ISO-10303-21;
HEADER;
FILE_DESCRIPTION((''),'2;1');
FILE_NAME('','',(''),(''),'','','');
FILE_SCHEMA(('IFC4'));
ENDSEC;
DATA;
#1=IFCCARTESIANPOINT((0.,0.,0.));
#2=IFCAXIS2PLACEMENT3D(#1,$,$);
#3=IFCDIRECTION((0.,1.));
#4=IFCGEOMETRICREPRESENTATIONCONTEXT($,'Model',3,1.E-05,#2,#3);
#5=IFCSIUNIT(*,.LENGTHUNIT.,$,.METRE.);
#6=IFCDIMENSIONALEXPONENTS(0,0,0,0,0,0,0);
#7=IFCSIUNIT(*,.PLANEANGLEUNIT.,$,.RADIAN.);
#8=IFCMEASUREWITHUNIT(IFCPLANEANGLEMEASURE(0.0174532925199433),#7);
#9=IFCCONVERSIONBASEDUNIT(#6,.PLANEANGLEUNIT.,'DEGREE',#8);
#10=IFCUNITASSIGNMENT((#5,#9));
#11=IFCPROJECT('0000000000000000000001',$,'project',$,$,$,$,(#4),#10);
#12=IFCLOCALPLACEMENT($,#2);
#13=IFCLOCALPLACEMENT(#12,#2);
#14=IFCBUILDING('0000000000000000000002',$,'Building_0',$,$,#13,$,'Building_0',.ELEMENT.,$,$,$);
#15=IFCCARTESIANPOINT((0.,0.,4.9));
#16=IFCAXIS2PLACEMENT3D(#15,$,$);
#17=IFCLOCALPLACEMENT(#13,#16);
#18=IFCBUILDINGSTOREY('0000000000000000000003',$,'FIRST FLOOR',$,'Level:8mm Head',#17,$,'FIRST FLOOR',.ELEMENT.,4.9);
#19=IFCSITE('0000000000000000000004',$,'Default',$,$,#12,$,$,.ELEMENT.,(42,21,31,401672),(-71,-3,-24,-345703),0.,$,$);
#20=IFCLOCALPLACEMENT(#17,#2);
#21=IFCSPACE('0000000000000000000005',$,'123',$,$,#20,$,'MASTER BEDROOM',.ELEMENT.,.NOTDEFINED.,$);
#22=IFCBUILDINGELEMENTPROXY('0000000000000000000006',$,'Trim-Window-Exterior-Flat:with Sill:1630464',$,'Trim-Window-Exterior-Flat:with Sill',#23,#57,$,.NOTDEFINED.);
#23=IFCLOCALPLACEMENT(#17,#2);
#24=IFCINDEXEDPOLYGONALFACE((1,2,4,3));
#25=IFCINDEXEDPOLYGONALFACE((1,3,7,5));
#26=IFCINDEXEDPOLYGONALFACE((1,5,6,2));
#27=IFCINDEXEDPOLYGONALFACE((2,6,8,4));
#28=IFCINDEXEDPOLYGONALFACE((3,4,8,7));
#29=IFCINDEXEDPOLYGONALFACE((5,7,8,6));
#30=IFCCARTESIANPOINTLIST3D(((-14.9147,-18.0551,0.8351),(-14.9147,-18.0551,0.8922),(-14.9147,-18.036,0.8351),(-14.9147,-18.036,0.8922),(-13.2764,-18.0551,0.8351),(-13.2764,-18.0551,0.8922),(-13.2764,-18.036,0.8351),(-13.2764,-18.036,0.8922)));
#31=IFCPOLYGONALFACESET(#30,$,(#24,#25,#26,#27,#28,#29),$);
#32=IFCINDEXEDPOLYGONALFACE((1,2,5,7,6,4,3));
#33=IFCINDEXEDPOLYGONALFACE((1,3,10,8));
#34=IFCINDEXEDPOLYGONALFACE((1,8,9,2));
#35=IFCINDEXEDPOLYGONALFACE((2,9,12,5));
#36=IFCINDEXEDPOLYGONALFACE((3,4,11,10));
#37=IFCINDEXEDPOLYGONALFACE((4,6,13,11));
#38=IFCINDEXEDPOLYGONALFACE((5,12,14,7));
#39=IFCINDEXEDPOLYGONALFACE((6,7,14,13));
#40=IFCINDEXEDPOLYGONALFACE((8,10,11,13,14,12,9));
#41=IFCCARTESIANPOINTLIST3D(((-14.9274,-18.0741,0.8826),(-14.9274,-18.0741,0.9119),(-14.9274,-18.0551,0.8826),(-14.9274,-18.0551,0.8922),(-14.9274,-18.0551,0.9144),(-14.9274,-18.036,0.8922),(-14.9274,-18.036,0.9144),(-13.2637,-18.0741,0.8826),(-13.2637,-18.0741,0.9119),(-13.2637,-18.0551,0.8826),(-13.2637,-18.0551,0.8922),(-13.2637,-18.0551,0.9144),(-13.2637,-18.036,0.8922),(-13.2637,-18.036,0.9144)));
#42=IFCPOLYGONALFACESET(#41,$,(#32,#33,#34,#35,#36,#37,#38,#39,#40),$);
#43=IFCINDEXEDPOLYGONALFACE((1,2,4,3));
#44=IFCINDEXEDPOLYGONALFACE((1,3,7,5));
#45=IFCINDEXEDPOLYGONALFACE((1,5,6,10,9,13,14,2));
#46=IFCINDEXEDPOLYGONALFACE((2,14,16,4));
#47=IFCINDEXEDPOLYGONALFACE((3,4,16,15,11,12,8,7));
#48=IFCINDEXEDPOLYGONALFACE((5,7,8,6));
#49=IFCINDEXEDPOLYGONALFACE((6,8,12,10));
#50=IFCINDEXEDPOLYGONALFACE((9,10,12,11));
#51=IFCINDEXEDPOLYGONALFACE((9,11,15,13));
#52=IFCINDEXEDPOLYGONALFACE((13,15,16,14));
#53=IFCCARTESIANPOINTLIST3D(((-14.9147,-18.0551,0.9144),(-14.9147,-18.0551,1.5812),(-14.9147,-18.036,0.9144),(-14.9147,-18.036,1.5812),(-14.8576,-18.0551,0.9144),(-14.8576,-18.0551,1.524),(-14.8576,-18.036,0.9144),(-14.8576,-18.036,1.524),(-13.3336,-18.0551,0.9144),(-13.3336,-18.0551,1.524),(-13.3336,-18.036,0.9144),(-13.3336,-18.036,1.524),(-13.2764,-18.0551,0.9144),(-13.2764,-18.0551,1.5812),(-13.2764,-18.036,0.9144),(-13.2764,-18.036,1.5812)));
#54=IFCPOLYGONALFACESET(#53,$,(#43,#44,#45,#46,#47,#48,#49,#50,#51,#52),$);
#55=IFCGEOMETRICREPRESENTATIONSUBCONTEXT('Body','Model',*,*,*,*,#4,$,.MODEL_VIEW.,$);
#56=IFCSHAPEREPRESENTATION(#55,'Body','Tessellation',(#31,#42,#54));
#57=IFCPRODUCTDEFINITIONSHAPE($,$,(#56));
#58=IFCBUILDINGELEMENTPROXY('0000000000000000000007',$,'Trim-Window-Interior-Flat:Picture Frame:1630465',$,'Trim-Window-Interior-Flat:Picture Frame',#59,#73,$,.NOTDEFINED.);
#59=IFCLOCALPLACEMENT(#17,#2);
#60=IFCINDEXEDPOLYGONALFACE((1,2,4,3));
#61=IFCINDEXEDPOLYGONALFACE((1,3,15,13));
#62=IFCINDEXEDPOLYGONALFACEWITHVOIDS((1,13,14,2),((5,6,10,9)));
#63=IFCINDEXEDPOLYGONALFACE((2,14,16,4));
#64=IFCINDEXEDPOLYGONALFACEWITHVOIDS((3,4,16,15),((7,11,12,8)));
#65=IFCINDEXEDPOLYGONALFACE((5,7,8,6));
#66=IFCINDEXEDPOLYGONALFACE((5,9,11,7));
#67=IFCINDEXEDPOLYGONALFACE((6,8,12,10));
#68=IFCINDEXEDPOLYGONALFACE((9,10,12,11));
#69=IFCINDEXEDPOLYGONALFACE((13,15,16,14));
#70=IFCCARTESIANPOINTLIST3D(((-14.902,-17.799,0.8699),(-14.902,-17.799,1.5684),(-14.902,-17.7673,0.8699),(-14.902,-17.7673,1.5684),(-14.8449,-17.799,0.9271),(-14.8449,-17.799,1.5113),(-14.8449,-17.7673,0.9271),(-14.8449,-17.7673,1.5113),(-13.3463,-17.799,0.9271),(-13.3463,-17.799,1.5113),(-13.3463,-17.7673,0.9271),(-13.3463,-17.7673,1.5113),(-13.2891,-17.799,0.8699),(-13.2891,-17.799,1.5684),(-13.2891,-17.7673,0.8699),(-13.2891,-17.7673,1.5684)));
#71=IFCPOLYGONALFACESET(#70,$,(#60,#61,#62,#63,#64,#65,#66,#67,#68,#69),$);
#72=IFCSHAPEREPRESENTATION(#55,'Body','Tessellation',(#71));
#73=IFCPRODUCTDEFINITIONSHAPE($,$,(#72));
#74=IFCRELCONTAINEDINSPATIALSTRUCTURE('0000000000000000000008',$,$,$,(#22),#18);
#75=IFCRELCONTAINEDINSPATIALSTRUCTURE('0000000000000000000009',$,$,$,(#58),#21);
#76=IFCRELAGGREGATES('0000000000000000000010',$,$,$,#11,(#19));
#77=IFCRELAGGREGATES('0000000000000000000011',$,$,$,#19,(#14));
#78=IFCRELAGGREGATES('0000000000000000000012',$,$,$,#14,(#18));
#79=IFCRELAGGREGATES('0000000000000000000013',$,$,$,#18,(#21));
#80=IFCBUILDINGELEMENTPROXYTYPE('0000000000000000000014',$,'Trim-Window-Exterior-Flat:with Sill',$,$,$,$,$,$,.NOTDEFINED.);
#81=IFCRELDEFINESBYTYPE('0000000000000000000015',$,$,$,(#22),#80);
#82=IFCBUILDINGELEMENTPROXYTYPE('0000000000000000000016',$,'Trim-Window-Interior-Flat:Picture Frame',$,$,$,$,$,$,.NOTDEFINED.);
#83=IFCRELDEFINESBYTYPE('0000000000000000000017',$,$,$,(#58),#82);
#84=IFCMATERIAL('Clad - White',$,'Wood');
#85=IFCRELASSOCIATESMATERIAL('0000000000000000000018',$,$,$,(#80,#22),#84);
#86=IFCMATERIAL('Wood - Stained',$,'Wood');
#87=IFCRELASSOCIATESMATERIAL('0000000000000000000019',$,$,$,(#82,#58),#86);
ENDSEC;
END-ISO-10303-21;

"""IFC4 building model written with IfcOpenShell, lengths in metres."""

from ifc_helpers import new_model, entity, si_unit, converted_unit, direction, frame, origin, place, context, subcontext, project, spatial, indexed_curve, outline, extrude, source, transform, mapped, material, type_object, type_shapes, element, save


model = new_model("IFC4")

# Units and contexts
model_context = context("Model", 3, precision=1e-05, world=origin(), true_north=direction((0.0, 1.0)))
body_context = subcontext(model_context, "Body", "Model", "MODEL_VIEW")
ifc_project = project(units=[si_unit("LENGTHUNIT", "METRE"), converted_unit("PLANEANGLEUNIT", "DEGREE", entity("IfcPlaneAngleMeasure", 0.0174532925199433), si_unit("PLANEANGLEUNIT", "RADIAN"), dimensions=[0, 0, 0, 0, 0, 0, 0])], contexts=[model_context])

# Site, building, storey
site_placement = place(None, origin())
site = spatial("IfcSite", under=ifc_project, at=site_placement, Name="Default", CompositionType="ELEMENT", RefLatitude=(42, 21, 31, 401672), RefLongitude=(-71, -3, -24, -345703), RefElevation=0.0)
building_placement = place(site_placement, origin())
building = spatial("IfcBuilding", under=site, at=building_placement, Name="Building_0", LongName="Building_0", CompositionType="ELEMENT")
storey_placement = place(building_placement, frame((0.0, 0.0, 4.9)))
storey = spatial("IfcBuildingStorey", under=building, at=storey_placement, Name="FIRST FLOOR", ObjectType="Level:8mm Head", LongName="FIRST FLOOR", CompositionType="ELEMENT", Elevation=4.9)

# Shared definitions
ifc_material_1 = material(Name="Clad - White", Category="Wood")

# Building element proxy
ifc_material_2 = material(Name="Wood - Stained", Category="Wood")
building_element_proxy_type_1 = type_object("IfcBuildingElementProxyType", Name="Trim-Window-Exterior-Flat:with Sill", PredefinedType="NOTDEFINED", material=ifc_material_1)
shared_shape_1 = source(origin(), body_context, "Body", "SweptSolid", [
    extrude(outline(indexed_curve([(-0.0286, -0.8191), (0.0286, -0.8191), (0.0286, 0.8191), (-0.0286, 0.8191), (-0.0286, -0.8191)], self_intersect=False)), frame((0.0, 0.6604, 0.0), z_axis=(0.0, 0.0, 1.0), x_axis=(0.0, 1.0, 0.0)), (0.0, 0.0, 1.0), 0.0191),
    extrude(outline(indexed_curve([(-0.016, -0.019), (0.0133, -0.019), (0.0158, 0.0), (0.0158, 0.019), (-0.0064, 0.019), (-0.0064, 0.0), (-0.016, 0.0), (-0.016, -0.019)], self_intersect=False)), frame((-0.8318, 0.6254, 0.019), z_axis=(1.0, 0.0, 0.0), x_axis=(0.0, -1.0, 0.0)), (0.0, 0.0, 1.0), 1.6637),
    extrude(outline(indexed_curve([(-0.8192, -0.3477), (0.8191, -0.3477), (0.8191, 0.3191), (0.762, 0.3191), (0.762, -0.2905), (-0.762, -0.2905), (-0.762, 0.3191), (-0.8192, 0.3191), (-0.8192, -0.3477)], self_intersect=False)), frame((0.0, 0.2905, 0.0)), (0.0, 0.0, 1.0), 0.0191),
])
type_shapes(building_element_proxy_type_1, [shared_shape_1])
proxy_1_placement = place(storey_placement, frame((-14.0956, -18.036, 1.524), z_axis=(0.0, -1.0, 0.0), x_axis=(-1.0, 0.0, 0.0)))
element("IfcBuildingElementProxy", 1, at=proxy_1_placement, inside=storey, type_object=building_element_proxy_type_1, material=ifc_material_1, Name="Trim-Window-Exterior-Flat:with Sill:1630464", ObjectType="Trim-Window-Exterior-Flat:with Sill", PredefinedType="NOTDEFINED", context=body_context, shape_type="MappedRepresentation", body=[
    mapped(shared_shape_1, transform((0.0, 0.0, 0.0), scale=1.0)),
])

# Shared definitions
space_placement = place(storey_placement, origin())
space = spatial("IfcSpace", under=storey, at=space_placement, Name="123", LongName="MASTER BEDROOM", CompositionType="ELEMENT", PredefinedType="NOTDEFINED")

# Building element proxy
building_element_proxy_type_2 = type_object("IfcBuildingElementProxyType", Name="Trim-Window-Interior-Flat:Picture Frame", PredefinedType="NOTDEFINED", material=ifc_material_2)
shared_shape_2 = source(origin(), body_context, "Body", "SweptSolid", [
    extrude(outline(indexed_curve([(-0.3492, -0.8064), (0.3492, -0.8064), (0.3492, 0.8064), (-0.3492, 0.8064), (-0.3492, -0.8064)], self_intersect=False), holes=[indexed_curve([(-0.2921, -0.7493), (-0.2921, 0.7493), (0.2921, 0.7493), (0.2921, -0.7493), (-0.2921, -0.7493)], self_intersect=False)]), frame((0.0, 0.3048, 0.0), z_axis=(0.0, 0.0, 1.0), x_axis=(0.0, 1.0, 0.0)), (0.0, 0.0, 1.0), 0.0318),
])
type_shapes(building_element_proxy_type_2, [shared_shape_2])
proxy_2_placement = place(space_placement, frame((-14.0956, -17.799, 1.524), z_axis=(0.0, 1.0, 0.0), x_axis=(1.0, 0.0, 0.0)))
element("IfcBuildingElementProxy", 2, at=proxy_2_placement, inside=space, type_object=building_element_proxy_type_2, material=ifc_material_2, Name="Trim-Window-Interior-Flat:Picture Frame:1630465", ObjectType="Trim-Window-Interior-Flat:Picture Frame", PredefinedType="NOTDEFINED", context=body_context, shape_type="MappedRepresentation", body=[
    mapped(shared_shape_2, transform((0.0, 0.0, 0.0), scale=1.0)),
])

save(model, "model.ifc")
